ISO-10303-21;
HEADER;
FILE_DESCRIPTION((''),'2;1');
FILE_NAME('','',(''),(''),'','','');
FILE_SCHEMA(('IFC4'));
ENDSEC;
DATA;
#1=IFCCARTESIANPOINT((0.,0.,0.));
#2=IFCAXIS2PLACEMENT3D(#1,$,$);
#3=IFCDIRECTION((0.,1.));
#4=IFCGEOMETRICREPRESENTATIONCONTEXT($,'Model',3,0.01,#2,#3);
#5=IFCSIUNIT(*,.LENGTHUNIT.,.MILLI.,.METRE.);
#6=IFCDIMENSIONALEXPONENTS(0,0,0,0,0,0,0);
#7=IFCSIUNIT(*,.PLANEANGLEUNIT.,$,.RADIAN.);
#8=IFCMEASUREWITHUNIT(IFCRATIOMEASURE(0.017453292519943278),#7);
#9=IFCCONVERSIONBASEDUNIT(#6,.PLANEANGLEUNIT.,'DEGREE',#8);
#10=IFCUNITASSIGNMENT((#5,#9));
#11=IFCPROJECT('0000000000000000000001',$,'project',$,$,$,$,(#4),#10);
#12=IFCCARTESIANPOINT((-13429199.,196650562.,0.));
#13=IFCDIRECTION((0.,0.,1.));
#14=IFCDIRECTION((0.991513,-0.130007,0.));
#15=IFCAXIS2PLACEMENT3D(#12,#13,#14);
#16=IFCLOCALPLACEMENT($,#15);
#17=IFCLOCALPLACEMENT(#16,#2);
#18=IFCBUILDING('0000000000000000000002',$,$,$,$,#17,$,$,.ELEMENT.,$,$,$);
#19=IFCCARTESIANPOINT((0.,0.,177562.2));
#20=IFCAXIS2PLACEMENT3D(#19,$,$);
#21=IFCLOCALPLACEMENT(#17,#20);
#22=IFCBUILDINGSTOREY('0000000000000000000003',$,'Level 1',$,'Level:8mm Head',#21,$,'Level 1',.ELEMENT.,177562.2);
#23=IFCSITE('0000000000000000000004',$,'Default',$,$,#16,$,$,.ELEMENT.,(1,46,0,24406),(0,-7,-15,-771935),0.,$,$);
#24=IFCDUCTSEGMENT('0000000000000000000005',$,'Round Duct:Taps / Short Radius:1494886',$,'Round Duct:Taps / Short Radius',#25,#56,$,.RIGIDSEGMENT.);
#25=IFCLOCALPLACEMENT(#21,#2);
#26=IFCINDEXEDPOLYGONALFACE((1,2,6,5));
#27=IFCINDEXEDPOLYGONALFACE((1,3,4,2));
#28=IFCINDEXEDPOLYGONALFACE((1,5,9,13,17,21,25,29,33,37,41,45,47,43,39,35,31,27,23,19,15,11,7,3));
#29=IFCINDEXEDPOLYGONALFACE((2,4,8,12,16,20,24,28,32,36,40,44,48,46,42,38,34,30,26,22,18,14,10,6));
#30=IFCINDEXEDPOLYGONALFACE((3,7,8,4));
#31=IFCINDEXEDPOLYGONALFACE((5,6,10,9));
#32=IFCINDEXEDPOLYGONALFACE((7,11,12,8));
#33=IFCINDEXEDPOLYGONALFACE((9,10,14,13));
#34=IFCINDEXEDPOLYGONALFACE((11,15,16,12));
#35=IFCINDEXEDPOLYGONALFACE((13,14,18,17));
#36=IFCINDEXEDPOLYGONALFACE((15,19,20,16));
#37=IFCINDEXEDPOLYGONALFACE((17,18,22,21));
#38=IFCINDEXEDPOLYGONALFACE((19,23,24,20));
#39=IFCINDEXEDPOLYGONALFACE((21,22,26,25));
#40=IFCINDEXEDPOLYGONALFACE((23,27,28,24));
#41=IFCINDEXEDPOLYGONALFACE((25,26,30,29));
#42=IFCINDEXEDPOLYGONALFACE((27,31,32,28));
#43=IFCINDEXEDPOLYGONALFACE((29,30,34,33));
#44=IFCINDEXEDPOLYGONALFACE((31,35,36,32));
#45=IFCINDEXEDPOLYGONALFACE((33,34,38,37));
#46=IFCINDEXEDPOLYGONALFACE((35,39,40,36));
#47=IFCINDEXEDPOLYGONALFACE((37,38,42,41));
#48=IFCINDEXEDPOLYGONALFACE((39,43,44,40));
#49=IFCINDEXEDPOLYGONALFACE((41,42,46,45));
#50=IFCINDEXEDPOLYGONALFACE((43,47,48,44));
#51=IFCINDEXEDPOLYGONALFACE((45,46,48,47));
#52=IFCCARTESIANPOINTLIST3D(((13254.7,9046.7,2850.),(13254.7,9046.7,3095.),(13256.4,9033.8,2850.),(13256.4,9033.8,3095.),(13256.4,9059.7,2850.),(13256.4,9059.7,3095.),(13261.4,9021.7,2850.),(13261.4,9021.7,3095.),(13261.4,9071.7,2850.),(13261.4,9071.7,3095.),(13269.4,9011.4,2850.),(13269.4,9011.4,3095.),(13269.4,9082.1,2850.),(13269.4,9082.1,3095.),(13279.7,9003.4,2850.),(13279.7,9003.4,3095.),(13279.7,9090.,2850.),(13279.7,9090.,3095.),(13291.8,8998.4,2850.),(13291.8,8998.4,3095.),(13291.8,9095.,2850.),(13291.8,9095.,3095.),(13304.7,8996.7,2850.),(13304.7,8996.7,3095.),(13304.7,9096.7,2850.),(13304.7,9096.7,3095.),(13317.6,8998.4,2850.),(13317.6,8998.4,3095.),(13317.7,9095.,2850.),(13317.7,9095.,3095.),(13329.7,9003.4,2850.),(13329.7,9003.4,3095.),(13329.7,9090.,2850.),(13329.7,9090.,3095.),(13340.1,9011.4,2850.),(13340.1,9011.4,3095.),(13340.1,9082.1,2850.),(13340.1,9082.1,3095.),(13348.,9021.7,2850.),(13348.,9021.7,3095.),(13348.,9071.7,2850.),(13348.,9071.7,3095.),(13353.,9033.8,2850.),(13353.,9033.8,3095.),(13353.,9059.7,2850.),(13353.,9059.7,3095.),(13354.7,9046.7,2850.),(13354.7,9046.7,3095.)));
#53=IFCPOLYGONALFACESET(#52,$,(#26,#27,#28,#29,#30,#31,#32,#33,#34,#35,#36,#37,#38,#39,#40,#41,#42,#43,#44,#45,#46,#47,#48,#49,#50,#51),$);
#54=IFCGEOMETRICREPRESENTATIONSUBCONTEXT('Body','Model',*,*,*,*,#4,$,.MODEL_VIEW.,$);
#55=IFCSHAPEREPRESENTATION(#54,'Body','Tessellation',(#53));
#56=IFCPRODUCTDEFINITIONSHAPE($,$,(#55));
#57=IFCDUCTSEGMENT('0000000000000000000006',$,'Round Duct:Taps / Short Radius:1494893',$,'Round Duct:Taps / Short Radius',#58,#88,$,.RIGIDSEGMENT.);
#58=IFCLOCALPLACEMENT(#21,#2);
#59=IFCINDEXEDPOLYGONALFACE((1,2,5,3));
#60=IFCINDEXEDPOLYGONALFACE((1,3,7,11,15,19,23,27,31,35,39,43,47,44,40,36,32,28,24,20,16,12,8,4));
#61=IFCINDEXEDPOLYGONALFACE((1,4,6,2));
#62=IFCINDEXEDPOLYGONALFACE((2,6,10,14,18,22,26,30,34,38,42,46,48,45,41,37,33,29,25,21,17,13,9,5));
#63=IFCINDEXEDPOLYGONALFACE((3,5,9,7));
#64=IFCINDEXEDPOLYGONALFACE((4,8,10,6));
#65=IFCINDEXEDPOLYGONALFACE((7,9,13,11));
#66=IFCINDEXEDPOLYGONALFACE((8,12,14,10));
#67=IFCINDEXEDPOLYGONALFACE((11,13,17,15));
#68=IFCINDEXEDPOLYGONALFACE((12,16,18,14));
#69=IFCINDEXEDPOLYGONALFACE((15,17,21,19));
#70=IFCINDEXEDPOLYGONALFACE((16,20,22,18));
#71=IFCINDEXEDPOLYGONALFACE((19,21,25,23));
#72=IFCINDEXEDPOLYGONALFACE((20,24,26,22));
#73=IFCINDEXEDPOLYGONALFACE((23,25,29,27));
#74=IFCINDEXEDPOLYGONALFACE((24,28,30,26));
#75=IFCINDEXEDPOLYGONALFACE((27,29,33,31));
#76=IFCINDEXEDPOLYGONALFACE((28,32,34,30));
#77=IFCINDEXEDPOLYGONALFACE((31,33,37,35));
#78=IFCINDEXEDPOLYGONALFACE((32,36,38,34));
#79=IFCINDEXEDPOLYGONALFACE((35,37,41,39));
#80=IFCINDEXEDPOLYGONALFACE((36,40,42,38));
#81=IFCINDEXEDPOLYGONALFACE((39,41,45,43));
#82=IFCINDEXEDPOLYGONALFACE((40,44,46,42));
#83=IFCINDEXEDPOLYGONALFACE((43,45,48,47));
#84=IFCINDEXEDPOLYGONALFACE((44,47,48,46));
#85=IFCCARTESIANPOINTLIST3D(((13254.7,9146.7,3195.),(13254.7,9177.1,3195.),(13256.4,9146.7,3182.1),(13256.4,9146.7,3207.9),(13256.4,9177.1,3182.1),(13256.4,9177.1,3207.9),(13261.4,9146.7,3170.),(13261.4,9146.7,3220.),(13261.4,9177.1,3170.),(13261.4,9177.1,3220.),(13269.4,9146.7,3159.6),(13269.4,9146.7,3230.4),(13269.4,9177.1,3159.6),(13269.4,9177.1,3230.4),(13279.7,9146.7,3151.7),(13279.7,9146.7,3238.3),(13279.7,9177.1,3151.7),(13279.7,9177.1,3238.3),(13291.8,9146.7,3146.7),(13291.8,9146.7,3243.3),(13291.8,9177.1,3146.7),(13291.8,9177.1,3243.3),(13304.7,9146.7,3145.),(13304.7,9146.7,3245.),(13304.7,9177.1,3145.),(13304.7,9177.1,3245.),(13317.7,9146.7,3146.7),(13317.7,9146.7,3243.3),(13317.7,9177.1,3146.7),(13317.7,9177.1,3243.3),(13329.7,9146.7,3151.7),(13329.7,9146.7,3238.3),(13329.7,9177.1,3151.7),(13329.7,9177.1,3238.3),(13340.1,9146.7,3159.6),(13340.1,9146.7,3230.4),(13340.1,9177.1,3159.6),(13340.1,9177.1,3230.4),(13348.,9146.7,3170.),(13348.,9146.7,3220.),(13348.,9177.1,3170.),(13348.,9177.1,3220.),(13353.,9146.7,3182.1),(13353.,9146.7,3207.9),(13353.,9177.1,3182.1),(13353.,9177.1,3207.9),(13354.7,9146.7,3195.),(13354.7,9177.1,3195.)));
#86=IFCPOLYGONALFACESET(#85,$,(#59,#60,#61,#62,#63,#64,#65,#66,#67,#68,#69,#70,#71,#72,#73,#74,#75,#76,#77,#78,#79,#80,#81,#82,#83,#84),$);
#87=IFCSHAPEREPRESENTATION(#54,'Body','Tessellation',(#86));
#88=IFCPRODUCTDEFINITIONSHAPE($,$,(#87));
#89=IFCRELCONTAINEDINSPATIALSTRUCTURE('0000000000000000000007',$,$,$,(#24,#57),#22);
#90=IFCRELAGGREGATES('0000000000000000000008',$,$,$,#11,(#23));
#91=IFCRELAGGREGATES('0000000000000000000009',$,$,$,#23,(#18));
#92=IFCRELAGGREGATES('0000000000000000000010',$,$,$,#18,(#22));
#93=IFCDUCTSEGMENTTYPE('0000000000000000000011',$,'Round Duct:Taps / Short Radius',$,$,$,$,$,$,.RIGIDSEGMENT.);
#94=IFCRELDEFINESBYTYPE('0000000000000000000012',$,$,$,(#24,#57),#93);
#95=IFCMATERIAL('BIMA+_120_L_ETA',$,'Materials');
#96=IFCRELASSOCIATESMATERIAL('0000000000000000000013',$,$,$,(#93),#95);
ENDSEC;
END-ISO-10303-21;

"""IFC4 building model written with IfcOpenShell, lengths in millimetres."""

from ifc_helpers import new_model, entity, si_unit, converted_unit, direction, frame, origin, place, context, subcontext, project, spatial, arc, indexed_curve, outline, extrude, material, type_object, element, save


model = new_model("IFC4")

# Units and contexts
model_context = context("Model", 3, precision=0.01, world=origin(), true_north=direction((0.0, 1.0)))
body_context = subcontext(model_context, "Body", "Model", "MODEL_VIEW")
ifc_project = project(units=[si_unit("LENGTHUNIT", "METRE", prefix="MILLI"), converted_unit("PLANEANGLEUNIT", "DEGREE", entity("IfcRatioMeasure", 0.017453292519943278), si_unit("PLANEANGLEUNIT", "RADIAN"), dimensions=[0, 0, 0, 0, 0, 0, 0])], contexts=[model_context])

# Site, building, storey
site_placement = place(None, frame((-13429199.0, 196650562.0, 0.0), z_axis=(0.0, 0.0, 1.0), x_axis=(0.991513, -0.130007, 0.0)))
site = spatial("IfcSite", under=ifc_project, at=site_placement, Name="Default", CompositionType="ELEMENT", RefLatitude=(1, 46, 0, 24406), RefLongitude=(0, -7, -15, -771935), RefElevation=0.0)
building_placement = place(site_placement, origin())
building = spatial("IfcBuilding", under=site, at=building_placement, CompositionType="ELEMENT")
storey_placement = place(building_placement, frame((0.0, 0.0, 177562.2)))
storey = spatial("IfcBuildingStorey", under=building, at=storey_placement, Name="Level 1", ObjectType="Level:8mm Head", LongName="Level 1", CompositionType="ELEMENT", Elevation=177562.2)

# Duct segments
ifc_material_1 = material(Name="BIMA+_120_L_ETA", Category="Materials")
duct_segment_type = type_object("IfcDuctSegmentType", Name="Round Duct:Taps / Short Radius", PredefinedType="RIGIDSEGMENT", material=ifc_material_1)
duct_segment_1_placement = place(storey_placement, frame((13253.1, 8995.1, 3095.0)))
element("IfcDuctSegment", 1, at=duct_segment_1_placement, inside=storey, type_object=duct_segment_type, Name="Round Duct:Taps / Short Radius:1494886", ObjectType="Round Duct:Taps / Short Radius", PredefinedType="RIGIDSEGMENT", context=body_context, shape_type="SweptSolid", body=[
    extrude(outline(indexed_curve([(50.0, 0.0), (35.4, 35.4), (0.0, 50.0), (-35.4, 35.4), (-50.0, 0.0), (-35.4, -35.4), (0.0, -50.0), (35.4, -35.4)], segments=[arc(1, 2, 3), arc(3, 4, 5), arc(5, 6, 7), arc(7, 8, 1)], self_intersect=False)), frame((51.6, 51.6, -245.0), z_axis=(0.0, 0.0, 1.0), x_axis=(-1.0, 0.000125, 0.0)), (0.0, 0.0, 1.0), 245.0),
])
duct_segment_2_placement = place(storey_placement, frame((13253.1, 9146.7, 3143.4)))
element("IfcDuctSegment", 2, at=duct_segment_2_placement, inside=storey, type_object=duct_segment_type, Name="Round Duct:Taps / Short Radius:1494893", ObjectType="Round Duct:Taps / Short Radius", PredefinedType="RIGIDSEGMENT", context=body_context, shape_type="SweptSolid", body=[
    extrude(outline(indexed_curve([(50.0, 0.0), (35.4, 35.4), (0.0, 50.0), (-35.4, 35.4), (-50.0, 0.0), (-35.4, -35.4), (0.0, -50.0), (35.4, -35.4)], segments=[arc(1, 2, 3), arc(3, 4, 5), arc(5, 6, 7), arc(7, 8, 1)], self_intersect=False)), frame((51.6, 0.0, 51.6), z_axis=(0.000125, 1.0, 0.0), x_axis=(-1.0, 0.000125, 0.0)), (0.0, 0.0, 1.0), 30.4),
])

save(model, "model.ifc")
